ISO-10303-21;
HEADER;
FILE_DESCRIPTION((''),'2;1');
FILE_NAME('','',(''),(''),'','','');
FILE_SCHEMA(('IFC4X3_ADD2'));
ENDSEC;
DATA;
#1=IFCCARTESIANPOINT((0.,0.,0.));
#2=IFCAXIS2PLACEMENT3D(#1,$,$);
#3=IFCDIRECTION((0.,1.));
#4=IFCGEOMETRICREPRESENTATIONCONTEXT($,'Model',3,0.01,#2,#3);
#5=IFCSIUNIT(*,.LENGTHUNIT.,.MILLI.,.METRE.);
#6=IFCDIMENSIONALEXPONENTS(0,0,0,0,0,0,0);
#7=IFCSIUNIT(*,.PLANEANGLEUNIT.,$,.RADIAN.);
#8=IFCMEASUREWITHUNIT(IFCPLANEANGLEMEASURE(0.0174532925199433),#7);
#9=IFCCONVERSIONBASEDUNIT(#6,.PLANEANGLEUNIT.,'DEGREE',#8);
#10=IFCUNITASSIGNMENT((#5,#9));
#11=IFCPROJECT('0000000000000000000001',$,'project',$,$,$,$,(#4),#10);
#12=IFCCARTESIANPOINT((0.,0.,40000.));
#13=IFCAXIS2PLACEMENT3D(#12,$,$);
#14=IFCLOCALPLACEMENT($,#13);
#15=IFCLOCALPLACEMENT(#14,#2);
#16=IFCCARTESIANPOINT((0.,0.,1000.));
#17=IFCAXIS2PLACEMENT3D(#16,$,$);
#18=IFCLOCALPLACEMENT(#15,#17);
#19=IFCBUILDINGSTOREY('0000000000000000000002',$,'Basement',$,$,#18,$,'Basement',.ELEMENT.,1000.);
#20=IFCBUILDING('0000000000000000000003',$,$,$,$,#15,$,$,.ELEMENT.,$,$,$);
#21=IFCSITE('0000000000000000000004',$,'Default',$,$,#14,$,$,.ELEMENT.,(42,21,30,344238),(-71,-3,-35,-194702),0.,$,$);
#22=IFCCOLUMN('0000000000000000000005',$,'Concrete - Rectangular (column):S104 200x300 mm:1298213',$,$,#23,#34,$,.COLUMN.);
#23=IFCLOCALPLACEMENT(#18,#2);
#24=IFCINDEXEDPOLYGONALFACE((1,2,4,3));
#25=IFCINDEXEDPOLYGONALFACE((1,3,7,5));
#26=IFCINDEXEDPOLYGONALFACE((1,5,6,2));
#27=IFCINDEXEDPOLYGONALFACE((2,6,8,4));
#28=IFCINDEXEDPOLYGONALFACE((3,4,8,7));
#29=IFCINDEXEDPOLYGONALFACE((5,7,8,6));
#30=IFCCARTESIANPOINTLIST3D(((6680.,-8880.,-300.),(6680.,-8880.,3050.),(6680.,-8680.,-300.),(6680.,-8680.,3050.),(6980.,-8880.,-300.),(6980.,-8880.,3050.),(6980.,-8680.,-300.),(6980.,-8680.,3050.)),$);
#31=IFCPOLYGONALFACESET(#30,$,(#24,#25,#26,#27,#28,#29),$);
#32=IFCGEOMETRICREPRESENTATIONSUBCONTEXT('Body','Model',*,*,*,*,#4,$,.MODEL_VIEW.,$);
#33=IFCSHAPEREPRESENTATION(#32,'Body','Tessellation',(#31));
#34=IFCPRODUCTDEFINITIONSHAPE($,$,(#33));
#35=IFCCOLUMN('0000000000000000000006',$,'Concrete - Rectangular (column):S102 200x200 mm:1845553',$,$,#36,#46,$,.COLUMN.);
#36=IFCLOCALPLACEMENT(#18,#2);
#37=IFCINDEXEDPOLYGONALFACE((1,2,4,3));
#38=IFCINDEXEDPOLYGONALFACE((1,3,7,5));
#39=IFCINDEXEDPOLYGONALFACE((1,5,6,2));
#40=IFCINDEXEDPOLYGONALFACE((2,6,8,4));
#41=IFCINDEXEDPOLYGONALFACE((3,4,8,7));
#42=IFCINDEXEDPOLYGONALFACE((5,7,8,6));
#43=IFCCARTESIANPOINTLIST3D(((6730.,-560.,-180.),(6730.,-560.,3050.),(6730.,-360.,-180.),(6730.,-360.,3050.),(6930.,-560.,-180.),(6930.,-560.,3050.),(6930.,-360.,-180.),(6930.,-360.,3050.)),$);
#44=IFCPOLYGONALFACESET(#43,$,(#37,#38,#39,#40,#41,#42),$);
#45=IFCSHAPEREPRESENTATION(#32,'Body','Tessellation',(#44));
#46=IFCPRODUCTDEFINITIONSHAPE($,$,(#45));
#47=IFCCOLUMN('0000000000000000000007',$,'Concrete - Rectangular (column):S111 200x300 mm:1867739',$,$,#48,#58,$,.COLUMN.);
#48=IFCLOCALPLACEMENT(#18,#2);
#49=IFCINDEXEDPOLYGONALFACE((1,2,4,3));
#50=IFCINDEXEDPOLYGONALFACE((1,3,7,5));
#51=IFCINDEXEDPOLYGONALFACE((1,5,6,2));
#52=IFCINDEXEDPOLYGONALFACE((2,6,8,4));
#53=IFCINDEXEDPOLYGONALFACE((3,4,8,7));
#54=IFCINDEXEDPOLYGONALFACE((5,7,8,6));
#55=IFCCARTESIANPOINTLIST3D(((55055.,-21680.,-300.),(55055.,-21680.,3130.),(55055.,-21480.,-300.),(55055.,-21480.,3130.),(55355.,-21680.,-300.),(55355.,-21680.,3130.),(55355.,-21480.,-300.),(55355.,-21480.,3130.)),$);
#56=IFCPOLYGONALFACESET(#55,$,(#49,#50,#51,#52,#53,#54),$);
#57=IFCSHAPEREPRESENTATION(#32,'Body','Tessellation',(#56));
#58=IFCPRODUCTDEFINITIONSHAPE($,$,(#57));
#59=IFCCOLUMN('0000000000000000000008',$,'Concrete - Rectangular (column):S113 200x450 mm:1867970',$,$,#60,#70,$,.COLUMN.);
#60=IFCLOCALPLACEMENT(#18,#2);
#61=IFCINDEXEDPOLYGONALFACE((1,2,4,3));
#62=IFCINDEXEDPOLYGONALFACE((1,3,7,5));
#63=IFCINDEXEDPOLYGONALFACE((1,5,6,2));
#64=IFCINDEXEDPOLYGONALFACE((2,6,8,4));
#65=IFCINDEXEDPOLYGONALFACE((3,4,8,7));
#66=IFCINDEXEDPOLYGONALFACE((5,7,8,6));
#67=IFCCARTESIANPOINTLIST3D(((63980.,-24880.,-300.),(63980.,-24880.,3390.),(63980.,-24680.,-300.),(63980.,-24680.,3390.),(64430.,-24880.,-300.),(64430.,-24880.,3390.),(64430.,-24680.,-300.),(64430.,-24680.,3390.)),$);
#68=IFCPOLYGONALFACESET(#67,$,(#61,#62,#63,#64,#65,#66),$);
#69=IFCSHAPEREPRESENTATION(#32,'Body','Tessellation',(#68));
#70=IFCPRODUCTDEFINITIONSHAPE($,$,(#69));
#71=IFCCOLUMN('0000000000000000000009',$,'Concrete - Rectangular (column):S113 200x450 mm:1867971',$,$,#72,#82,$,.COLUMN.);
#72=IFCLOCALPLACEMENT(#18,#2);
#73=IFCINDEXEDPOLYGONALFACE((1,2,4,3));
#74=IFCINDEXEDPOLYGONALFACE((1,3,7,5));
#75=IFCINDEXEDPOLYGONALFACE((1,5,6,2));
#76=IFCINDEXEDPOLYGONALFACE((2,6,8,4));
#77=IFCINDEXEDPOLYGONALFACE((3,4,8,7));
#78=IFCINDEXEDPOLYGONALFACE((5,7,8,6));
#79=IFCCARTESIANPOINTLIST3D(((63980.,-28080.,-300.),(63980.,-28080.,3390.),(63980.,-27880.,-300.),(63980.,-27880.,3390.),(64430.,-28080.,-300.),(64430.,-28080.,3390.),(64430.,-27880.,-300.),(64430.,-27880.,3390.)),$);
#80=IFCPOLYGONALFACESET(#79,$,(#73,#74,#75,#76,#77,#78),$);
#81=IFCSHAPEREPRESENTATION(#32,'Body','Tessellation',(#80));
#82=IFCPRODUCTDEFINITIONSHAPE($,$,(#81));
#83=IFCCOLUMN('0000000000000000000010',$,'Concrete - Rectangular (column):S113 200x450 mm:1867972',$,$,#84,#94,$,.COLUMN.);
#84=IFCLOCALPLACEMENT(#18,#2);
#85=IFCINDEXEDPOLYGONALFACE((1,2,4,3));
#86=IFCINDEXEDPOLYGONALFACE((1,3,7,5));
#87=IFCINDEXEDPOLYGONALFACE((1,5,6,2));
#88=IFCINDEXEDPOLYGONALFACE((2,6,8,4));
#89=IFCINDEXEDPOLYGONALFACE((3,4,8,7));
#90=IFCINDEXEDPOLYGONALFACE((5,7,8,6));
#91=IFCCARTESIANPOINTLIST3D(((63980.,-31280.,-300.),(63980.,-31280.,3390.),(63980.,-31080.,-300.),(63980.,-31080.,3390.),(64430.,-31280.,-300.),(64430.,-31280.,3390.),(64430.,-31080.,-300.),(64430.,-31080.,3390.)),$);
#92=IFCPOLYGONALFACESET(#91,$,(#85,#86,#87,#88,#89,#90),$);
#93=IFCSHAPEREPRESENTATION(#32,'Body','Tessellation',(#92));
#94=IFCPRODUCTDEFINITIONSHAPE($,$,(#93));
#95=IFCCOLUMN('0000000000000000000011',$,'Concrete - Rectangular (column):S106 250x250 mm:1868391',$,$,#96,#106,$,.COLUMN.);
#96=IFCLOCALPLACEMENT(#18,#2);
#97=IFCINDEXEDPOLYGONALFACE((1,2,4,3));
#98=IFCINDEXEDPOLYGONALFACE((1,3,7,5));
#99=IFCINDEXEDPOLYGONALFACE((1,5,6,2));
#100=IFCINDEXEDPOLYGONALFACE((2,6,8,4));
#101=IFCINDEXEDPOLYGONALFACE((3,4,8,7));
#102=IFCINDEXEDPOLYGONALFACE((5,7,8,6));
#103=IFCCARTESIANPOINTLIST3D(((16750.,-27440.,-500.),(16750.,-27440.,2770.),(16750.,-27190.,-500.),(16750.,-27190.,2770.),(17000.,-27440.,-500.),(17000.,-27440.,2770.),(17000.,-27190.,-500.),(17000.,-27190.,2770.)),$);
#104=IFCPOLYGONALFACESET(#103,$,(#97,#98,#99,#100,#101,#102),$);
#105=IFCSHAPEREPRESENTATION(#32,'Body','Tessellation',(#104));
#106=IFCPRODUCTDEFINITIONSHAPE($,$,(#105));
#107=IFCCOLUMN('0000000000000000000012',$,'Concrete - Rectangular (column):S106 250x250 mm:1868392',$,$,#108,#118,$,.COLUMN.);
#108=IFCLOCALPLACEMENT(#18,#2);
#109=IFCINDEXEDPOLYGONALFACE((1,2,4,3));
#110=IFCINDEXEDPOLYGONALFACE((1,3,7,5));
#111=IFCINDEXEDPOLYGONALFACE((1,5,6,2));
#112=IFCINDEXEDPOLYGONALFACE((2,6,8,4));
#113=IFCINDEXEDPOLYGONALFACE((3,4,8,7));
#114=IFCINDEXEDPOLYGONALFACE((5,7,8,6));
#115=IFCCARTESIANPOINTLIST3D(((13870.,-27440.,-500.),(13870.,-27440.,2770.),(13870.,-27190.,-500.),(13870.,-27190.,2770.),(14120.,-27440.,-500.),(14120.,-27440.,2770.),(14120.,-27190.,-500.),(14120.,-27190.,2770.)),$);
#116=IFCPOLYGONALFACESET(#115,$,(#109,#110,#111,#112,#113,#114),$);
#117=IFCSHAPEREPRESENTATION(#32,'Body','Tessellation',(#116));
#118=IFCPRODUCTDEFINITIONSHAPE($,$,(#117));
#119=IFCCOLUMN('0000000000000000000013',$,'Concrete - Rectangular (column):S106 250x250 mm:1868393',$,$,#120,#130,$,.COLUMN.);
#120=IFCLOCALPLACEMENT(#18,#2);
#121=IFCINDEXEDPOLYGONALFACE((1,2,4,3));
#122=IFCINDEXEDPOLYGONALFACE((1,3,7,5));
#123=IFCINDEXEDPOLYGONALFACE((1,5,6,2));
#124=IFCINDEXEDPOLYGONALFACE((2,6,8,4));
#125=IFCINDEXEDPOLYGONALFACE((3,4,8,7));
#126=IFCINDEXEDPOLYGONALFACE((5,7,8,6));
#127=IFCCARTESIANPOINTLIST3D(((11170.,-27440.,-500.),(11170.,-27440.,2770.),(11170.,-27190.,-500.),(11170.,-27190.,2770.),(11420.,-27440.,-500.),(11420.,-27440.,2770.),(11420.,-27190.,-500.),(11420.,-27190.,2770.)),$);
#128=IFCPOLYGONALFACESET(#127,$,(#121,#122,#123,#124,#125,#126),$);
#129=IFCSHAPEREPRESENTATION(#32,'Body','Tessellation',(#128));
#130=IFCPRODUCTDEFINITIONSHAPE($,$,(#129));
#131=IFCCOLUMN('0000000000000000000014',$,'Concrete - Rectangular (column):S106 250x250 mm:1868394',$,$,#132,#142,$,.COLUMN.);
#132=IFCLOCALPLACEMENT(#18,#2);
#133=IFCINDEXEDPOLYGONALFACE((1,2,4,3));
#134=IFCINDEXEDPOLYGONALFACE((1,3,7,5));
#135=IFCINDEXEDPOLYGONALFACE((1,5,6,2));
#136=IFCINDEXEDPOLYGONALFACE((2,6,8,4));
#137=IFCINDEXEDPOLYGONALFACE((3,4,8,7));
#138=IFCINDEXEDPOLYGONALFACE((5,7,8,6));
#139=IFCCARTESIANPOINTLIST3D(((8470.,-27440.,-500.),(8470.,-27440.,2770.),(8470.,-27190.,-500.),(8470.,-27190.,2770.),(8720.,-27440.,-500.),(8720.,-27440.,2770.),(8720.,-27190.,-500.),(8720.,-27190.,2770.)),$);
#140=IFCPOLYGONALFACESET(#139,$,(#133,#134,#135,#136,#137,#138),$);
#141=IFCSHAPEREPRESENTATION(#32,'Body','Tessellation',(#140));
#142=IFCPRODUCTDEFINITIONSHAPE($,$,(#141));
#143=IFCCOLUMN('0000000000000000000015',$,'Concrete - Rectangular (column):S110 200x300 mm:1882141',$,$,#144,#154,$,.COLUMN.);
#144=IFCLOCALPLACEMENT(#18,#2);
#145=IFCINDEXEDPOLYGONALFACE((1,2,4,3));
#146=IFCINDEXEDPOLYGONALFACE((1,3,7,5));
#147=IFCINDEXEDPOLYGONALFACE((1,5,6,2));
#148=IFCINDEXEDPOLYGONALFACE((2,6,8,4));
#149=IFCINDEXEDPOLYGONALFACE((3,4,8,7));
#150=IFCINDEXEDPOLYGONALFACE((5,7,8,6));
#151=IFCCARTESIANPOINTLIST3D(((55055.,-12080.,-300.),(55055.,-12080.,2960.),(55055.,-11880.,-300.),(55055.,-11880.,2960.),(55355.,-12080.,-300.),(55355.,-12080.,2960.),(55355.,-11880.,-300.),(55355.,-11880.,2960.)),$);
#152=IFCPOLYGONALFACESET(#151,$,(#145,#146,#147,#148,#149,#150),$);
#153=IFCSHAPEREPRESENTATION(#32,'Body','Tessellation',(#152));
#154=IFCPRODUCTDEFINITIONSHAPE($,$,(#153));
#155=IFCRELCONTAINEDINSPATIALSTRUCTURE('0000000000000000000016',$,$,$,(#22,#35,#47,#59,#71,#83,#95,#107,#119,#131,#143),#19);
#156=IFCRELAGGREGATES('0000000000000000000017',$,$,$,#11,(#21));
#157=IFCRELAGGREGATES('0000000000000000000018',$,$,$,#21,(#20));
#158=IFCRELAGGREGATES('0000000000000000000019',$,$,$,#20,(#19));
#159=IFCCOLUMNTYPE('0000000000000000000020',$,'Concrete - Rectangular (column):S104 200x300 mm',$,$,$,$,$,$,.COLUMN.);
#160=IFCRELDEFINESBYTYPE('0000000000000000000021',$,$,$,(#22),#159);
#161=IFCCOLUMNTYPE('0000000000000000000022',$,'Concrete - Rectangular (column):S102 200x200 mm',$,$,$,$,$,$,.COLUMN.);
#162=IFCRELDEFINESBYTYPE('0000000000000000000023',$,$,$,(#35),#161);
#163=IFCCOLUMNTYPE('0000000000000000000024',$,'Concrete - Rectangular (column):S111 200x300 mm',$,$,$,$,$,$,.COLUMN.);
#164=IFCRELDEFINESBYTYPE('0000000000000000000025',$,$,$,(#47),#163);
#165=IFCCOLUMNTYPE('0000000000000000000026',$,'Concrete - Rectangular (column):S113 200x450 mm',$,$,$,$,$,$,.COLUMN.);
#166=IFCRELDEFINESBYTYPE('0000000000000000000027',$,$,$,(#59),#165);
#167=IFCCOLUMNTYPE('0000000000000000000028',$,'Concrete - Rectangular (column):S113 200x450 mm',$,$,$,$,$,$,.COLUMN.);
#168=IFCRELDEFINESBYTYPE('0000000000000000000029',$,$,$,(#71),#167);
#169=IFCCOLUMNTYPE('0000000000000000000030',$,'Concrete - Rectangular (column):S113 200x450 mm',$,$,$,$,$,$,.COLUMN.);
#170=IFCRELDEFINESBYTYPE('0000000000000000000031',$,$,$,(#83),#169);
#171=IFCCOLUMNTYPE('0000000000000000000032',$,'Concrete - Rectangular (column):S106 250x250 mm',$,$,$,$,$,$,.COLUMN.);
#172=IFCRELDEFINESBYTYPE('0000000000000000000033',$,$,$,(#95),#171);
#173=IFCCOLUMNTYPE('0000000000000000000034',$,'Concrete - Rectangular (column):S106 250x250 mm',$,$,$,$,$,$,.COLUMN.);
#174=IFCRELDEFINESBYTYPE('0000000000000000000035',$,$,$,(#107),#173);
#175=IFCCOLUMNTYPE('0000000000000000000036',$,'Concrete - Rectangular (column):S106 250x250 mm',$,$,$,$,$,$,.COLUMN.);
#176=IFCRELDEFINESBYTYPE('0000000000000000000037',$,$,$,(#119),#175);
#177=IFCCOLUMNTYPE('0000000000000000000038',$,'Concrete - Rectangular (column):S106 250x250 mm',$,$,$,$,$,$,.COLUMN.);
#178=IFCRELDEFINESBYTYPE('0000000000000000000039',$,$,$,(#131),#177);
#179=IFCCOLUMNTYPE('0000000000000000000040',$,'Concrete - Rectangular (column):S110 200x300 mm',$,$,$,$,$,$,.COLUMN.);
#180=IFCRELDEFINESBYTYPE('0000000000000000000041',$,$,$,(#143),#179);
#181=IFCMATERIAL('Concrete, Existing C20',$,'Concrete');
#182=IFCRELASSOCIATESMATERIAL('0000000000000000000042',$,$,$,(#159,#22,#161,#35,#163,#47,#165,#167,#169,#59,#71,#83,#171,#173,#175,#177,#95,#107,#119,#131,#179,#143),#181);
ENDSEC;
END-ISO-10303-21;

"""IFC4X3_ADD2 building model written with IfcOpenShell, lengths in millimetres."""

from ifc_helpers import new_model, entity, si_unit, converted_unit, direction, frame, frame_2d, origin, origin_2d_with_axis, place, context, subcontext, project, spatial, rectangle, extrude, source, transform, mapped, material, material_profile, profile_set, profile_usage, type_object, type_shapes, element, save


model = new_model("IFC4X3_ADD2")

# Units and contexts
model_context = context("Model", 3, precision=0.01, world=origin(), true_north=direction((0.0, 1.0)))
body_context = subcontext(model_context, "Body", "Model", "MODEL_VIEW")
ifc_project = project(units=[si_unit("LENGTHUNIT", "METRE", prefix="MILLI"), converted_unit("PLANEANGLEUNIT", "DEGREE", entity("IfcPlaneAngleMeasure", 0.0174532925199433), si_unit("PLANEANGLEUNIT", "RADIAN"), dimensions=[0, 0, 0, 0, 0, 0, 0])], contexts=[model_context])

# Site, building, storey
site_placement = place(None, frame((0.0, 0.0, 40000.0)))
site = spatial("IfcSite", under=ifc_project, at=site_placement, Name="Default", CompositionType="ELEMENT", RefLatitude=(42, 21, 30, 344238), RefLongitude=(-71, -3, -35, -194702), RefElevation=0.0)
building_placement = place(site_placement, origin())
building = spatial("IfcBuilding", under=site, at=building_placement, CompositionType="ELEMENT")
storey_placement = place(building_placement, frame((0.0, 0.0, 1000.0)))
storey = spatial("IfcBuildingStorey", under=building, at=storey_placement, Name="Basement", LongName="Basement", CompositionType="ELEMENT", Elevation=1000.0)

# Columns
ifc_material = material(Name="Concrete, Existing C20", Category="Concrete")
ifc_material_profile_1 = material_profile(ifc_material, rectangle(XDim=200.0, YDim=300.0, at=frame_2d((0.0, 0.0), x_axis=(1.0, 0.0))), Name="S104 200x300 mm")
ifc_profile_set_1 = profile_set([ifc_material_profile_1], Name="S104 200x300 mm")
ifc_profile_usage_1 = profile_usage(ifc_profile_set_1)
column_type_1 = type_object("IfcColumnType", Name="Concrete - Rectangular (column):S104 200x300 mm", PredefinedType="COLUMN", material=ifc_profile_set_1)
shared_shape_1 = source(origin(), body_context, "Body", "SweptSolid", [
    extrude(rectangle(XDim=200.0, YDim=300.0, at=frame_2d((0.0, 0.0), x_axis=(1.0, 0.0))), frame((6830.0, -8780.0, 700.0), z_axis=(0.0, 0.0, 1.0), x_axis=(0.0, 1.0, 0.0)), (0.0, 0.0, 1.0), 3350.0),
])
type_shapes(column_type_1, [shared_shape_1])
column_1_placement = place(storey_placement, frame((0.0, 0.0, -1000.0)))
element("IfcColumn", 1, at=column_1_placement, inside=storey, type_object=column_type_1, material=ifc_profile_usage_1, Name="Concrete - Rectangular (column):S104 200x300 mm:1298213", PredefinedType="COLUMN", context=body_context, shape_type="MappedRepresentation", body=[
    mapped(shared_shape_1, transform((0.0, 0.0, 0.0), scale=1.0)),
])
ifc_material_profile_2 = material_profile(ifc_material, rectangle(XDim=200.0, YDim=200.0, at=frame_2d((0.0, 0.0), x_axis=(1.0, 0.0))), Name="S102 200x200 mm")
ifc_profile_set_2 = profile_set([ifc_material_profile_2], Name="S102 200x200 mm")
ifc_profile_usage_2 = profile_usage(ifc_profile_set_2)
column_type_2 = type_object("IfcColumnType", Name="Concrete - Rectangular (column):S102 200x200 mm", PredefinedType="COLUMN", material=ifc_profile_set_2)
shared_shape_2 = source(origin(), body_context, "Body", "SweptSolid", [
    extrude(rectangle(XDim=200.0, YDim=200.0, at=frame_2d((0.0, 0.0), x_axis=(1.0, 0.0))), frame((6830.0, -460.0, 820.0), z_axis=(0.0, 0.0, 1.0), x_axis=(0.0, 1.0, 0.0)), (0.0, 0.0, 1.0), 3230.0),
])
type_shapes(column_type_2, [shared_shape_2])
column_2_placement = place(storey_placement, frame((0.0, 0.0, -1000.0)))
element("IfcColumn", 2, at=column_2_placement, inside=storey, type_object=column_type_2, material=ifc_profile_usage_2, Name="Concrete - Rectangular (column):S102 200x200 mm:1845553", PredefinedType="COLUMN", context=body_context, shape_type="MappedRepresentation", body=[
    mapped(shared_shape_2, transform((0.0, 0.0, 0.0), scale=1.0)),
])
ifc_material_profile_3 = material_profile(ifc_material, rectangle(XDim=200.0, YDim=300.0, at=origin_2d_with_axis()), Name="S111 200x300 mm")
ifc_profile_set_3 = profile_set([ifc_material_profile_3], Name="S111 200x300 mm")
ifc_profile_usage_3 = profile_usage(ifc_profile_set_3)
column_type_3 = type_object("IfcColumnType", Name="Concrete - Rectangular (column):S111 200x300 mm", PredefinedType="COLUMN", material=ifc_profile_set_3)
shared_shape_3 = source(origin(), body_context, "Body", "SweptSolid", [
    extrude(rectangle(XDim=200.0, YDim=300.0, at=origin_2d_with_axis()), frame((55205.0, -21580.0, 700.0), z_axis=(0.0, 0.0, 1.0), x_axis=(0.0, 1.0, 0.0)), (0.0, 0.0, 1.0), 3430.0),
])
type_shapes(column_type_3, [shared_shape_3])
column_3_placement = place(storey_placement, frame((0.0, 0.0, -1000.0)))
element("IfcColumn", 3, at=column_3_placement, inside=storey, type_object=column_type_3, material=ifc_profile_usage_3, Name="Concrete - Rectangular (column):S111 200x300 mm:1867739", PredefinedType="COLUMN", context=body_context, shape_type="MappedRepresentation", body=[
    mapped(shared_shape_3, transform((0.0, 0.0, 0.0), scale=1.0)),
])
ifc_material_profile_4 = material_profile(ifc_material, rectangle(XDim=3690.0, YDim=200.0, at=frame_2d((0.0, 0.0), x_axis=(1.0, 0.0))), Name="S113 200x450 mm")
ifc_profile_set_4 = profile_set([ifc_material_profile_4], Name="S113 200x450 mm")
ifc_profile_usage_4 = profile_usage(ifc_profile_set_4)
column_type_4 = type_object("IfcColumnType", Name="Concrete - Rectangular (column):S113 200x450 mm", PredefinedType="COLUMN", material=ifc_profile_set_4)
shared_shape_4 = source(origin(), body_context, "Body", "SweptSolid", [
    extrude(rectangle(XDim=3690.0, YDim=200.0, at=frame_2d((0.0, 0.0), x_axis=(1.0, 0.0))), frame((63980.0, -24780.0, 2545.0), z_axis=(1.0, 0.0, 0.0), x_axis=(0.0, 0.0, 1.0)), (0.0, 0.0, 1.0), 450.0),
])
type_shapes(column_type_4, [shared_shape_4])
column_4_placement = place(storey_placement, frame((0.0, 0.0, -1000.0)))
element("IfcColumn", 4, at=column_4_placement, inside=storey, type_object=column_type_4, material=ifc_profile_usage_4, Name="Concrete - Rectangular (column):S113 200x450 mm:1867970", PredefinedType="COLUMN", context=body_context, shape_type="MappedRepresentation", body=[
    mapped(shared_shape_4, transform((0.0, 0.0, 0.0), scale=1.0)),
])
column_type_5 = type_object("IfcColumnType", Name="Concrete - Rectangular (column):S113 200x450 mm", PredefinedType="COLUMN", material=ifc_profile_set_4)
shared_shape_5 = source(origin(), body_context, "Body", "SweptSolid", [
    extrude(rectangle(XDim=3690.0, YDim=200.0, at=frame_2d((0.0, 0.0), x_axis=(1.0, 0.0))), frame((63980.0, -27980.0, 2545.0), z_axis=(1.0, 0.0, 0.0), x_axis=(0.0, 0.0, 1.0)), (0.0, 0.0, 1.0), 450.0),
])
type_shapes(column_type_5, [shared_shape_5])
column_5_placement = place(storey_placement, frame((0.0, 0.0, -1000.0)))
element("IfcColumn", 5, at=column_5_placement, inside=storey, type_object=column_type_5, material=ifc_profile_usage_4, Name="Concrete - Rectangular (column):S113 200x450 mm:1867971", PredefinedType="COLUMN", context=body_context, shape_type="MappedRepresentation", body=[
    mapped(shared_shape_5, transform((0.0, 0.0, 0.0), scale=1.0)),
])
column_type_6 = type_object("IfcColumnType", Name="Concrete - Rectangular (column):S113 200x450 mm", PredefinedType="COLUMN", material=ifc_profile_set_4)
shared_shape_6 = source(origin(), body_context, "Body", "SweptSolid", [
    extrude(rectangle(XDim=3690.0, YDim=200.0, at=frame_2d((0.0, 0.0), x_axis=(1.0, 0.0))), frame((63980.0, -31180.0, 2545.0), z_axis=(1.0, 0.0, 0.0), x_axis=(0.0, 0.0, 1.0)), (0.0, 0.0, 1.0), 450.0),
])
type_shapes(column_type_6, [shared_shape_6])
column_6_placement = place(storey_placement, frame((0.0, 0.0, -1000.0)))
element("IfcColumn", 6, at=column_6_placement, inside=storey, type_object=column_type_6, material=ifc_profile_usage_4, Name="Concrete - Rectangular (column):S113 200x450 mm:1867972", PredefinedType="COLUMN", context=body_context, shape_type="MappedRepresentation", body=[
    mapped(shared_shape_6, transform((0.0, 0.0, 0.0), scale=1.0)),
])
ifc_material_profile_5 = material_profile(ifc_material, rectangle(XDim=250.0, YDim=250.0, at=frame_2d((0.0, 0.0), x_axis=(1.0, 0.0))), Name="S106 250x250 mm")
ifc_profile_set_5 = profile_set([ifc_material_profile_5], Name="S106 250x250 mm")
ifc_profile_usage_5 = profile_usage(ifc_profile_set_5)
column_type_7 = type_object("IfcColumnType", Name="Concrete - Rectangular (column):S106 250x250 mm", PredefinedType="COLUMN", material=ifc_profile_set_5)
shared_shape_7 = source(origin(), body_context, "Body", "SweptSolid", [
    extrude(rectangle(XDim=250.0, YDim=250.0, at=frame_2d((0.0, 0.0), x_axis=(1.0, 0.0))), frame((16875.0, -27315.0, 500.0), z_axis=(0.0, 0.0, 1.0), x_axis=(0.0, 1.0, 0.0)), (0.0, 0.0, 1.0), 3270.0),
])
type_shapes(column_type_7, [shared_shape_7])
column_7_placement = place(storey_placement, frame((0.0, 0.0, -1000.0)))
element("IfcColumn", 7, at=column_7_placement, inside=storey, type_object=column_type_7, material=ifc_profile_usage_5, Name="Concrete - Rectangular (column):S106 250x250 mm:1868391", PredefinedType="COLUMN", context=body_context, shape_type="MappedRepresentation", body=[
    mapped(shared_shape_7, transform((0.0, 0.0, 0.0), scale=1.0)),
])
column_type_8 = type_object("IfcColumnType", Name="Concrete - Rectangular (column):S106 250x250 mm", PredefinedType="COLUMN", material=ifc_profile_set_5)
shared_shape_8 = source(origin(), body_context, "Body", "SweptSolid", [
    extrude(rectangle(XDim=250.0, YDim=250.0, at=frame_2d((0.0, 0.0), x_axis=(1.0, 0.0))), frame((13995.0, -27315.0, 500.0), z_axis=(0.0, 0.0, 1.0), x_axis=(0.0, 1.0, 0.0)), (0.0, 0.0, 1.0), 3270.0),
])
type_shapes(column_type_8, [shared_shape_8])
column_8_placement = place(storey_placement, frame((0.0, 0.0, -1000.0)))
element("IfcColumn", 8, at=column_8_placement, inside=storey, type_object=column_type_8, material=ifc_profile_usage_5, Name="Concrete - Rectangular (column):S106 250x250 mm:1868392", PredefinedType="COLUMN", context=body_context, shape_type="MappedRepresentation", body=[
    mapped(shared_shape_8, transform((0.0, 0.0, 0.0), scale=1.0)),
])
column_type_9 = type_object("IfcColumnType", Name="Concrete - Rectangular (column):S106 250x250 mm", PredefinedType="COLUMN", material=ifc_profile_set_5)
shared_shape_9 = source(origin(), body_context, "Body", "SweptSolid", [
    extrude(rectangle(XDim=250.0, YDim=250.0, at=frame_2d((0.0, 0.0), x_axis=(1.0, 0.0))), frame((11295.0, -27315.0, 500.0), z_axis=(0.0, 0.0, 1.0), x_axis=(0.0, 1.0, 0.0)), (0.0, 0.0, 1.0), 3270.0),
])
type_shapes(column_type_9, [shared_shape_9])
column_9_placement = place(storey_placement, frame((0.0, 0.0, -1000.0)))
element("IfcColumn", 9, at=column_9_placement, inside=storey, type_object=column_type_9, material=ifc_profile_usage_5, Name="Concrete - Rectangular (column):S106 250x250 mm:1868393", PredefinedType="COLUMN", context=body_context, shape_type="MappedRepresentation", body=[
    mapped(shared_shape_9, transform((0.0, 0.0, 0.0), scale=1.0)),
])
column_type_10 = type_object("IfcColumnType", Name="Concrete - Rectangular (column):S106 250x250 mm", PredefinedType="COLUMN", material=ifc_profile_set_5)
shared_shape_10 = source(origin(), body_context, "Body", "SweptSolid", [
    extrude(rectangle(XDim=250.0, YDim=250.0, at=frame_2d((0.0, 0.0), x_axis=(1.0, 0.0))), frame((8595.0, -27315.0, 500.0), z_axis=(0.0, 0.0, 1.0), x_axis=(0.0, 1.0, 0.0)), (0.0, 0.0, 1.0), 3270.0),
])
type_shapes(column_type_10, [shared_shape_10])
column_10_placement = place(storey_placement, frame((0.0, 0.0, -1000.0)))
element("IfcColumn", 10, at=column_10_placement, inside=storey, type_object=column_type_10, material=ifc_profile_usage_5, Name="Concrete - Rectangular (column):S106 250x250 mm:1868394", PredefinedType="COLUMN", context=body_context, shape_type="MappedRepresentation", body=[
    mapped(shared_shape_10, transform((0.0, 0.0, 0.0), scale=1.0)),
])
ifc_material_profile_6 = material_profile(ifc_material, rectangle(XDim=200.0, YDim=300.0, at=origin_2d_with_axis()), Name="S110 200x300 mm")
ifc_profile_set_6 = profile_set([ifc_material_profile_6], Name="S110 200x300 mm")
ifc_profile_usage_6 = profile_usage(ifc_profile_set_6)
column_type_11 = type_object("IfcColumnType", Name="Concrete - Rectangular (column):S110 200x300 mm", PredefinedType="COLUMN", material=ifc_profile_set_6)
shared_shape_11 = source(origin(), body_context, "Body", "SweptSolid", [
    extrude(rectangle(XDim=200.0, YDim=300.0, at=frame_2d((0.0, 0.0), x_axis=(1.0, 0.0))), frame((55205.0, -11980.0, 700.0), z_axis=(0.0, 0.0, 1.0), x_axis=(0.0, 1.0, 0.0)), (0.0, 0.0, 1.0), 3260.0),
])
type_shapes(column_type_11, [shared_shape_11])
column_11_placement = place(storey_placement, frame((0.0, 0.0, -1000.0)))
element("IfcColumn", 11, at=column_11_placement, inside=storey, type_object=column_type_11, material=ifc_profile_usage_6, Name="Concrete - Rectangular (column):S110 200x300 mm:1882141", PredefinedType="COLUMN", context=body_context, shape_type="MappedRepresentation", body=[
    mapped(shared_shape_11, transform((0.0, 0.0, 0.0), scale=1.0)),
])

save(model, "model.ifc")
